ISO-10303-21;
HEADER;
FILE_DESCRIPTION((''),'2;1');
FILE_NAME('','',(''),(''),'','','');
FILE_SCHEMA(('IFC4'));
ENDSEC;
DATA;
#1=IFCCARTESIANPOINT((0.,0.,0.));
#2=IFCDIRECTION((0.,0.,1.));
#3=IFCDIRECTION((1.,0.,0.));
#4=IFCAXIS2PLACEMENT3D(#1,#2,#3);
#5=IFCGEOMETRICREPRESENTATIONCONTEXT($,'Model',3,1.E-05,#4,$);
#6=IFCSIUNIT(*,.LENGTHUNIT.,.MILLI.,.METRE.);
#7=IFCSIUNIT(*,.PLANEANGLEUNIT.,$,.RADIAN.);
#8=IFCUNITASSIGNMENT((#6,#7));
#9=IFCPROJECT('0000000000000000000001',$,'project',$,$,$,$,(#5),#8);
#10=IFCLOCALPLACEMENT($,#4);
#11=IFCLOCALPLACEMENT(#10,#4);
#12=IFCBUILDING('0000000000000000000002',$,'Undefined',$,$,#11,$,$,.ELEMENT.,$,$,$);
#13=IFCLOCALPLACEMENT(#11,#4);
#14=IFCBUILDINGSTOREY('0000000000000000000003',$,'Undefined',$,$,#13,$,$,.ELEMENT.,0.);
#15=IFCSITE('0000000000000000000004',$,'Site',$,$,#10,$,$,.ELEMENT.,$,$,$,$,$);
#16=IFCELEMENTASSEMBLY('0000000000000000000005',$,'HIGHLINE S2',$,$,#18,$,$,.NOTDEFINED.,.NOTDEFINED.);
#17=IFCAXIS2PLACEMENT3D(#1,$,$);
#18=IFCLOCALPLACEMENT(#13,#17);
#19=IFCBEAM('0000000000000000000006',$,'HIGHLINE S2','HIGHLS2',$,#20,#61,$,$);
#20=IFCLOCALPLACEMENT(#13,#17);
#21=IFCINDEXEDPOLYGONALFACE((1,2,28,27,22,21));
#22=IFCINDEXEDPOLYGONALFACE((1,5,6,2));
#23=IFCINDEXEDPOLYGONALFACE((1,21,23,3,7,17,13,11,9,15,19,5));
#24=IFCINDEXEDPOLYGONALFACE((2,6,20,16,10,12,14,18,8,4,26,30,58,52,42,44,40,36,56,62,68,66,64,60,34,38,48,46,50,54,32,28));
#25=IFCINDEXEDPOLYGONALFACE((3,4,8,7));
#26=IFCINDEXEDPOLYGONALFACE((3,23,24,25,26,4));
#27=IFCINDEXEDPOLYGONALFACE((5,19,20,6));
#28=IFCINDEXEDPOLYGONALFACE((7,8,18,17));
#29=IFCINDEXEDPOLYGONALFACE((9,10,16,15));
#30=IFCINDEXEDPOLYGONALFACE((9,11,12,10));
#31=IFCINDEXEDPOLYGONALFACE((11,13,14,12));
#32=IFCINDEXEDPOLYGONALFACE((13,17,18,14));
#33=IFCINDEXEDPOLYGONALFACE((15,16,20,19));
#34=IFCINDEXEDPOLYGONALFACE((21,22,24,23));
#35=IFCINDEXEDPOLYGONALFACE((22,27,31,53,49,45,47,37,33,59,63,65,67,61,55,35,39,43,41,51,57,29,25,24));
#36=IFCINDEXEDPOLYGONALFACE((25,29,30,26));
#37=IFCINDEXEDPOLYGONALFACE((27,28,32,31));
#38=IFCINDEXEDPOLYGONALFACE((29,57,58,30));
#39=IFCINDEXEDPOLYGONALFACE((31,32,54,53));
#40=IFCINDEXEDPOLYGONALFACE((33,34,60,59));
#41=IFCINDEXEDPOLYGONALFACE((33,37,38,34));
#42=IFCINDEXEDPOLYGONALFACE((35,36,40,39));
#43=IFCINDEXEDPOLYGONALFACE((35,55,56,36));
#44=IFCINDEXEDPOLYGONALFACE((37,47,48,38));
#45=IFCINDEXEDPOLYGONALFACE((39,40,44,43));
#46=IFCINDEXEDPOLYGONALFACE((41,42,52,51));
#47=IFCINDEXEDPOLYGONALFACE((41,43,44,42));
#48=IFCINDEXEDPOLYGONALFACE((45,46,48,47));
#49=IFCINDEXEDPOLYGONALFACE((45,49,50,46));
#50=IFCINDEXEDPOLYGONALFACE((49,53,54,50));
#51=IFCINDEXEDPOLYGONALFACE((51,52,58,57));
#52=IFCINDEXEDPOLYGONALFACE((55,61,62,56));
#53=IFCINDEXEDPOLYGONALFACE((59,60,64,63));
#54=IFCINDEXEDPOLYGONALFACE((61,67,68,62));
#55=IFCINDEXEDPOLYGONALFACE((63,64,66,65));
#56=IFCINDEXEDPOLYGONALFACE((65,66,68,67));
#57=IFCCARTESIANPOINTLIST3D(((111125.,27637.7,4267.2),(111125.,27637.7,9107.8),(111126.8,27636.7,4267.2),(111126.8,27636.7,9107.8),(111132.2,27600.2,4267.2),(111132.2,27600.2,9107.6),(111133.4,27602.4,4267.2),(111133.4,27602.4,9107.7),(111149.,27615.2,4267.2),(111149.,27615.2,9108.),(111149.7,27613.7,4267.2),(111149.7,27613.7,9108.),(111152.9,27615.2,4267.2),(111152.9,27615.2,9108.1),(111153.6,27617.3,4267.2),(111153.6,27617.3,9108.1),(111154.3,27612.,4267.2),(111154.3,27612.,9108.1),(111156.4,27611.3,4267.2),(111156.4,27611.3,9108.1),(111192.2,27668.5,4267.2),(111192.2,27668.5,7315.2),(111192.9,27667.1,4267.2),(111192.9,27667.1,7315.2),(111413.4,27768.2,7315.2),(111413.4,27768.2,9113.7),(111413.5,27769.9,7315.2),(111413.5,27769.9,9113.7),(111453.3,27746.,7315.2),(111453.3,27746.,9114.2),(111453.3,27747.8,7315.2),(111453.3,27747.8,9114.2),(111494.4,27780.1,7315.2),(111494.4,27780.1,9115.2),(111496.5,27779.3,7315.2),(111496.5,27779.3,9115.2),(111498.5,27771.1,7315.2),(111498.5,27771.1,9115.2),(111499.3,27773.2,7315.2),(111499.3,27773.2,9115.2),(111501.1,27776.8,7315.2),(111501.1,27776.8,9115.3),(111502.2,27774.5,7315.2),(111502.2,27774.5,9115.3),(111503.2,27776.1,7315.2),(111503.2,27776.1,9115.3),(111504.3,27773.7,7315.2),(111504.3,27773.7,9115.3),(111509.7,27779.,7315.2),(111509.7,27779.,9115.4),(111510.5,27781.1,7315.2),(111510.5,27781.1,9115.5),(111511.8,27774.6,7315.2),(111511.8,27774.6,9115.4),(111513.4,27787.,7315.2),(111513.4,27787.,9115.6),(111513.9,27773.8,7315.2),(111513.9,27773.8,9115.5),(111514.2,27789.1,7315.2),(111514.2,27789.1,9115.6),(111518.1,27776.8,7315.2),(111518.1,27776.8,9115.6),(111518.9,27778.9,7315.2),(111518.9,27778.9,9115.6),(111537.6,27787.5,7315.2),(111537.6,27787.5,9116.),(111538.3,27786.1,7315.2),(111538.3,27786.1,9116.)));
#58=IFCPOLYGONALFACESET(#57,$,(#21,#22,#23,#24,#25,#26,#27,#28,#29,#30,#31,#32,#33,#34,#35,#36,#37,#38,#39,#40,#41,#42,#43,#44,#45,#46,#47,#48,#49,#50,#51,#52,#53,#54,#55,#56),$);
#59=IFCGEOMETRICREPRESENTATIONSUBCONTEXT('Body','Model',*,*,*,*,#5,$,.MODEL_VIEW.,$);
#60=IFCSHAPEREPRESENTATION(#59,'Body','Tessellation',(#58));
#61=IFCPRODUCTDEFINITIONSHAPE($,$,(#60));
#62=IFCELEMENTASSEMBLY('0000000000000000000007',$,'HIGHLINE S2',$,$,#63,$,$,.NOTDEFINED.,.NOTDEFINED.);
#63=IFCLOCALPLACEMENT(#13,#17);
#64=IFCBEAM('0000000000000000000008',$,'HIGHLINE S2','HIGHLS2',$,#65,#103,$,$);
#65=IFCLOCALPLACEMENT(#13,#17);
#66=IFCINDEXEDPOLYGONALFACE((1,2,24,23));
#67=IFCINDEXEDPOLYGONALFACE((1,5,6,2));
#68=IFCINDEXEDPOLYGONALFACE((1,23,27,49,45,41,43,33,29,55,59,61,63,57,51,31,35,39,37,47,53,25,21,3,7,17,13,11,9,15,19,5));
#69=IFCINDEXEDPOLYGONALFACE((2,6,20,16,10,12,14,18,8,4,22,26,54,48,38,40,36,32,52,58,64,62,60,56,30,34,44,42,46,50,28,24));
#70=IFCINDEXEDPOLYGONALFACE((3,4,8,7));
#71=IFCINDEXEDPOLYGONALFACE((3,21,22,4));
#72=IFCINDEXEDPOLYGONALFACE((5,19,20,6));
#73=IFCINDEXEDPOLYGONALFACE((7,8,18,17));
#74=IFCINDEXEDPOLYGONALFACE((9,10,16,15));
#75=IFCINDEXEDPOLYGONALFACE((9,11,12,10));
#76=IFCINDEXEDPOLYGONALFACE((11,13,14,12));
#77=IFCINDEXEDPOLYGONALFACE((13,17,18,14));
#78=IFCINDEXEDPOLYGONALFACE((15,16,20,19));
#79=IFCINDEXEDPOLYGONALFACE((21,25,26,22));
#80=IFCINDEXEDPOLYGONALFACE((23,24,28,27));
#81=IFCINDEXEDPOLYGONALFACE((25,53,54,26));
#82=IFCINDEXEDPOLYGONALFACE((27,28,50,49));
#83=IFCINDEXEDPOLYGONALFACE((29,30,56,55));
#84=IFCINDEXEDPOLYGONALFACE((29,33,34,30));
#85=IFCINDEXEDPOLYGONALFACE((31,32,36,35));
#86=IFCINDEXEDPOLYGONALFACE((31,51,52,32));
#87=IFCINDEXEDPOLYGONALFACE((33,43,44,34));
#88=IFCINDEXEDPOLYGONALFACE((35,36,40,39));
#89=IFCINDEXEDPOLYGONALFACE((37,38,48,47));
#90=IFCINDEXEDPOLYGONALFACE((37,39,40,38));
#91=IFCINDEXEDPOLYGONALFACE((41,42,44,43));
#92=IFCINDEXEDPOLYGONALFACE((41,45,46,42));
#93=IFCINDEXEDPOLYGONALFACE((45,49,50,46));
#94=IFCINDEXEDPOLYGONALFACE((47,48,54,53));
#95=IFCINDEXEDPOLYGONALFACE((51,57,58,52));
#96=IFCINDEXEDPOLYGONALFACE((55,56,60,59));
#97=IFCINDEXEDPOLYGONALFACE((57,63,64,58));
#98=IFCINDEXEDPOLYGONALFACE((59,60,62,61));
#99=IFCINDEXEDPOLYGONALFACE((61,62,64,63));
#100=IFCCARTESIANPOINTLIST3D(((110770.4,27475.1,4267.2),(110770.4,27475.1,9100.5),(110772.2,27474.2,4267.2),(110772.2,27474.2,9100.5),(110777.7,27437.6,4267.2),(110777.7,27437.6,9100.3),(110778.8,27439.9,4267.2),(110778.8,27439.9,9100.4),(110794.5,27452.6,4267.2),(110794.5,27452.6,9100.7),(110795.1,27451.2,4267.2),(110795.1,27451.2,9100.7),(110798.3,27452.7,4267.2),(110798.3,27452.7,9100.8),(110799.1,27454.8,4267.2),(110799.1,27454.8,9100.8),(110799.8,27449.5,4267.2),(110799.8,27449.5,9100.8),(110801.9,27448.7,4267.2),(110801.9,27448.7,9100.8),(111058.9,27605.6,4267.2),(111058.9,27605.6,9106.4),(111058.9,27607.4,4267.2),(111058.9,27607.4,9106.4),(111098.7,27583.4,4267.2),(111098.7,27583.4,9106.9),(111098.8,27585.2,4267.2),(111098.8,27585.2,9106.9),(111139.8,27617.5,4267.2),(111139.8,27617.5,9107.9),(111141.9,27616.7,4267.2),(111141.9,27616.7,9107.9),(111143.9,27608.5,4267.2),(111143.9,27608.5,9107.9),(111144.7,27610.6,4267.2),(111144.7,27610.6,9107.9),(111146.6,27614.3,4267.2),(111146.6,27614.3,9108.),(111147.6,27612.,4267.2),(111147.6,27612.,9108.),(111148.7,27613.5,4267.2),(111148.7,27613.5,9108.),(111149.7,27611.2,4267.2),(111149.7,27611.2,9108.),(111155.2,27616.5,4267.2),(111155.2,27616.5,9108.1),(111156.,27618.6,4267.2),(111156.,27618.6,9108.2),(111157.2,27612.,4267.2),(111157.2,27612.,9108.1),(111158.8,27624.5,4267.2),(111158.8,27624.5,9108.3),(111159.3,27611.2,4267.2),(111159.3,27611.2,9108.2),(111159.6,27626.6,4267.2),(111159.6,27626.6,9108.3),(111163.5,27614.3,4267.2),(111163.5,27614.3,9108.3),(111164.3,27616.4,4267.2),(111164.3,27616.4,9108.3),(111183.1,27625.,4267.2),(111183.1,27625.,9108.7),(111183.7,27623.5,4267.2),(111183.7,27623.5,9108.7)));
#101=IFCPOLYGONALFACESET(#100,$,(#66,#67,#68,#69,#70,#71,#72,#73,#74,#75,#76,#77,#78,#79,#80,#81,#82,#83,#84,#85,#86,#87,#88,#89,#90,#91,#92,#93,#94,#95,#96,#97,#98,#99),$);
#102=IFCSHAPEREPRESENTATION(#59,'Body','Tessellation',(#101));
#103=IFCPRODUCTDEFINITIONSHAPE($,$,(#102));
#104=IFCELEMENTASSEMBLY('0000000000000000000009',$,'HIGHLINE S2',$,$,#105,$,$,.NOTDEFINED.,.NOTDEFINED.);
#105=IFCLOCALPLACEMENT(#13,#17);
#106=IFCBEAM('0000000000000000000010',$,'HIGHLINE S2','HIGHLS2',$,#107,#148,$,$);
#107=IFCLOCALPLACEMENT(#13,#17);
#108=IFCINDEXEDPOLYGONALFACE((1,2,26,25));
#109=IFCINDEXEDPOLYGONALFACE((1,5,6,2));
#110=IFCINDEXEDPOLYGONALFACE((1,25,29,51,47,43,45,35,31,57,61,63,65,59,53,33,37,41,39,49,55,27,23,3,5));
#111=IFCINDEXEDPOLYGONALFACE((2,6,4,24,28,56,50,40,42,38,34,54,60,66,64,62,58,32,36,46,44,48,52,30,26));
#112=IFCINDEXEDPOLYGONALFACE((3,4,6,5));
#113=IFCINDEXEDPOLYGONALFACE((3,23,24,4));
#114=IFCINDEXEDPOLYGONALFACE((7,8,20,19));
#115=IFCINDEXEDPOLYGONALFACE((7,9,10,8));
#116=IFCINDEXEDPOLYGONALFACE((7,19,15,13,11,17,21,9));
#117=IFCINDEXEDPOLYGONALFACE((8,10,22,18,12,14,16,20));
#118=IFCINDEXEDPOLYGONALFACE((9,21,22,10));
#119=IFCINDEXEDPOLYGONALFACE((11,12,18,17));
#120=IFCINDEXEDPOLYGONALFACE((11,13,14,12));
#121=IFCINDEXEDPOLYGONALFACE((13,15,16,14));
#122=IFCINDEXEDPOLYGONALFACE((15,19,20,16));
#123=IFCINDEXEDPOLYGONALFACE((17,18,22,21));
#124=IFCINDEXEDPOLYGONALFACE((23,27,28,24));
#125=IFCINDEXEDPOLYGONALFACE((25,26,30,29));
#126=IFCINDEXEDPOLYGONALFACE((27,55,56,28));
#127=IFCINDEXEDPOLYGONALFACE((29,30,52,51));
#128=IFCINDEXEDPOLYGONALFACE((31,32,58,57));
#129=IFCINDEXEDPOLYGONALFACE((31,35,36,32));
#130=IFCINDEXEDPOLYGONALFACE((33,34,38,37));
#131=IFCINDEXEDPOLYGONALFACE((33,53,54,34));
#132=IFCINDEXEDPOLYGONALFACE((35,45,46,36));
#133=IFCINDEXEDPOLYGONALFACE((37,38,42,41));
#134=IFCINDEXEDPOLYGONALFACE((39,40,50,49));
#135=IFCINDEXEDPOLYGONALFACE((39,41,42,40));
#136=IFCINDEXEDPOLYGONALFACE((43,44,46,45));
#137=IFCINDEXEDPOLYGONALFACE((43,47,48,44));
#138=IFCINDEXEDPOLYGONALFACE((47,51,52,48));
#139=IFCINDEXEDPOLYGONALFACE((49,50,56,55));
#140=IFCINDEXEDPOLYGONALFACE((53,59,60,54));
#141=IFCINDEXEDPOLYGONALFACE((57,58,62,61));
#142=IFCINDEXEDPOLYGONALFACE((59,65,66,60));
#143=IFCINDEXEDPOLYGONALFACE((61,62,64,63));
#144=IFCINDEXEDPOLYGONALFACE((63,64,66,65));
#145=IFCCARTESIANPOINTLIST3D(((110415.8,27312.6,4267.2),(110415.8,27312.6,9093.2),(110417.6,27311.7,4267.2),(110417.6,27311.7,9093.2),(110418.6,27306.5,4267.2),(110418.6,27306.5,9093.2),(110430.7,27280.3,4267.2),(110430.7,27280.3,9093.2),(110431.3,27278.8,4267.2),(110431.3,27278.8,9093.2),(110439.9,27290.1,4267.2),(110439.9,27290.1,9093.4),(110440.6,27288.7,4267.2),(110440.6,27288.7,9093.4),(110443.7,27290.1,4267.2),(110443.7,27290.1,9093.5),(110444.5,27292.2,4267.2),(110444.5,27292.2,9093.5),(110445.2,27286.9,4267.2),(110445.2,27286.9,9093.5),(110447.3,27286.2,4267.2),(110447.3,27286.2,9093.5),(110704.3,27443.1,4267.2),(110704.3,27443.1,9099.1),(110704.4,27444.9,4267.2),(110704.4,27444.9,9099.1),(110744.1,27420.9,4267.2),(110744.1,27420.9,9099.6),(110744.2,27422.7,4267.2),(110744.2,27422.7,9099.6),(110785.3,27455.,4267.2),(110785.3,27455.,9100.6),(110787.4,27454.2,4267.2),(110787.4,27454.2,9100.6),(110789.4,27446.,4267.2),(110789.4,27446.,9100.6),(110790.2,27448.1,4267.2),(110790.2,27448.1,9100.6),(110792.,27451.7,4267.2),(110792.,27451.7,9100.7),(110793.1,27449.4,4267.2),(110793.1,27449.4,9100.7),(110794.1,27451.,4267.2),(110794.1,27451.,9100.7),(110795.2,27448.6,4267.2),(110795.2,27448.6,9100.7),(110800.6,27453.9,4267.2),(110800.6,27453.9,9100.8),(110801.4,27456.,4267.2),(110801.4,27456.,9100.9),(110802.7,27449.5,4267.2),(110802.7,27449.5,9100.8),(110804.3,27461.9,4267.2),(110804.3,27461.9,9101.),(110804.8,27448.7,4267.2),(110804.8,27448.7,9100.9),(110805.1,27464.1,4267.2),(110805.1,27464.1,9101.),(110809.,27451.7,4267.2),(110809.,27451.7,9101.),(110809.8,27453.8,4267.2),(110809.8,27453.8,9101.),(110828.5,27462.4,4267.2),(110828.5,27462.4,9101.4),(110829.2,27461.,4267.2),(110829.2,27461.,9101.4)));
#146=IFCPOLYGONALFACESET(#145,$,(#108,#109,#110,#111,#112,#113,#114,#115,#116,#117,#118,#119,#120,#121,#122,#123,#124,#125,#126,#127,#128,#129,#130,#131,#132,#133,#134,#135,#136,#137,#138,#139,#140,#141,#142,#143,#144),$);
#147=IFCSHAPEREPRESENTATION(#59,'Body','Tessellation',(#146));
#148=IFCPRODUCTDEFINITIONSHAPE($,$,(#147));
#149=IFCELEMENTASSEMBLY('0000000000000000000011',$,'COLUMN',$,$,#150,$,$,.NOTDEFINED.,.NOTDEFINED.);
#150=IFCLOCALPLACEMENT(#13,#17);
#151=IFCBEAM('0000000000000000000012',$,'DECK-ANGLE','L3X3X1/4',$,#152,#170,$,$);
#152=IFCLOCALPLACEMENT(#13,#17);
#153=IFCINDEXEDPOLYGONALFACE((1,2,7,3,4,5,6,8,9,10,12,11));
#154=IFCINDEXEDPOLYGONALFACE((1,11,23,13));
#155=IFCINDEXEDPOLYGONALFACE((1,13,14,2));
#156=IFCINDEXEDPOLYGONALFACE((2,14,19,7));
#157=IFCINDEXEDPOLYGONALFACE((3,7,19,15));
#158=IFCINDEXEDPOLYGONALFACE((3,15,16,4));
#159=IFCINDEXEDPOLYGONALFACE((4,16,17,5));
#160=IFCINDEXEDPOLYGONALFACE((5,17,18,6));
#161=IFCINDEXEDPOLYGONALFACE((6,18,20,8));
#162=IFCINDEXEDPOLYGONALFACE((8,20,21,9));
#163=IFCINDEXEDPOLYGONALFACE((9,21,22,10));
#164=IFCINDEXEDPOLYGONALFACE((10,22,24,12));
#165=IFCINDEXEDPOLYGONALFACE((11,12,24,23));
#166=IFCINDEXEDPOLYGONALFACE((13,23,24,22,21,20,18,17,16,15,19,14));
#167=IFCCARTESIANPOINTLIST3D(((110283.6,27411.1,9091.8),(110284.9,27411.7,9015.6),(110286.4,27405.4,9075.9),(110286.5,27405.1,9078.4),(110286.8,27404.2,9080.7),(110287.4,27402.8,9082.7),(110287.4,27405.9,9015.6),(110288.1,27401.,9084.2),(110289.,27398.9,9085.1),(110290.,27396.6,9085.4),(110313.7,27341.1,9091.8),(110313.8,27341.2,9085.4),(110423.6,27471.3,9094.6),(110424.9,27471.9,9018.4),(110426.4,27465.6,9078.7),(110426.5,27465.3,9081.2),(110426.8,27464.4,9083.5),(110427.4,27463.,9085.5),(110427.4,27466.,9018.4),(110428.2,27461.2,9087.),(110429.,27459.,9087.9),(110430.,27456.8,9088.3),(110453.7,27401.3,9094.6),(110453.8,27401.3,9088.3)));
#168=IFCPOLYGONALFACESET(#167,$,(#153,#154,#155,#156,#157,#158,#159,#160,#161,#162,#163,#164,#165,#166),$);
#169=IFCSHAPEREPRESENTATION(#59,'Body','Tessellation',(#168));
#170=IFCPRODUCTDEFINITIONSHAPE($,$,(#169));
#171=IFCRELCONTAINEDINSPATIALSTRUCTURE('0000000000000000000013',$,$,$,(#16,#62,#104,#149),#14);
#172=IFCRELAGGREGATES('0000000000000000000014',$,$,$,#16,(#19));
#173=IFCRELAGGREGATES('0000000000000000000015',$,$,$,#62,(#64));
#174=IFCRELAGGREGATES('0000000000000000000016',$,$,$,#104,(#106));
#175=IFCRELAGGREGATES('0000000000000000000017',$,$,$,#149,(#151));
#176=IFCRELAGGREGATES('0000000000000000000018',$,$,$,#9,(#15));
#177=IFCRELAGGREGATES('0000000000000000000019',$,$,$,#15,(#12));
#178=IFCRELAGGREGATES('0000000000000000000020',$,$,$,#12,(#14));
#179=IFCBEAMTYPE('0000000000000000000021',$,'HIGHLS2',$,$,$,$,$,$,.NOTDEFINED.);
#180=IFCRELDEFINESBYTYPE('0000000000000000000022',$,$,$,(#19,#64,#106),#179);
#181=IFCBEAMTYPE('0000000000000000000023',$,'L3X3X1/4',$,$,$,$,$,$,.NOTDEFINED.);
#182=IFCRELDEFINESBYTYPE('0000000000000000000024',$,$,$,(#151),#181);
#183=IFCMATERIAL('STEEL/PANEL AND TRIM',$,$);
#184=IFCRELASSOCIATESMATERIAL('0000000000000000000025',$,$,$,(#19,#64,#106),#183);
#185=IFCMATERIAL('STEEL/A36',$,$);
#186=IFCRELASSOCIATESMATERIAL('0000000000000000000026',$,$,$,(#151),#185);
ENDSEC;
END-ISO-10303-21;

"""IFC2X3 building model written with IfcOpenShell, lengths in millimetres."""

from ifc_helpers import new_model, si_unit, frame, origin_with_axes, origin_2d_with_axis, place, context, subcontext, project, spatial, polyline, l_section, outline, extrude, boolean, clip, halfspace, material, type_object, element, aggregate, save


model = new_model("IFC2X3")

# Units and contexts
model_context = context("Model", 3, precision=1e-05, world=origin_with_axes())
body_context = subcontext(model_context, "Body", "Model", "MODEL_VIEW")
ifc_project = project(units=[si_unit("LENGTHUNIT", "METRE", prefix="MILLI"), si_unit("PLANEANGLEUNIT", "RADIAN")], contexts=[model_context])

# Site, building, storey
site_placement = place(None, origin_with_axes())
site = spatial("IfcSite", under=ifc_project, at=site_placement, Name="Site", CompositionType="ELEMENT")
building_placement = place(site_placement, origin_with_axes())
building = spatial("IfcBuilding", under=site, at=building_placement, Name="Undefined", CompositionType="ELEMENT")
storey_placement = place(building_placement, origin_with_axes())
storey = spatial("IfcBuildingStorey", under=building, at=storey_placement, Name="Undefined", CompositionType="ELEMENT", Elevation=0.0)

# Element assemblies, beams
ifc_material_1 = material(Name="STEEL/PANEL AND TRIM")
beam_type_1 = type_object("IfcBeamType", Name="HIGHLS2", PredefinedType="NOTDEFINED")
assembly_1_placement = place(storey_placement, origin_with_axes())
assembly_1 = element("IfcElementAssembly", 1, at=assembly_1_placement, inside=storey, Name="HIGHLINE S2", AssemblyPlace="NOTDEFINED", PredefinedType="NOTDEFINED")
beam_1_placement = place(assembly_1_placement, frame((111125.0, 27637.7, 4267.2), z_axis=(0.41674, -0.909026, 0.0), x_axis=(0.0, 0.0, 1.0)))
beam_1 = element("IfcBeam", 2, at=beam_1_placement, type_object=beam_type_1, material=ifc_material_1, Name="HIGHLINE S2", Description="HIGHLS2", context=body_context, shape_type="CSG", body=[
    boolean("DIFFERENCE", boolean("DIFFERENCE", extrude(outline(polyline([(415.4, 26.1), (415.4, 37.3), (437.6, 37.3), (437.6, 35.7), (417.0, 35.7), (417.0, 24.5), (395.1, 24.5), (395.1, 34.4), (401.5, 34.4), (401.5, 31.9), (408.7, 31.9), (408.7, 36.8), (344.4, 36.8), (317.4, 0.0), (0.0, 0.0), (-9.0, 37.1), (17.6, 37.1), (17.6, 30.5), (12.5, 30.5), (12.5, 32.1), (16.0, 32.1), (16.0, 35.5), (-7.0, 35.5), (1.2, 1.6), (316.6, 1.6), (343.6, 38.4), (410.3, 38.4), (410.3, 30.3), (400.0, 30.3), (400.0, 32.8), (396.7, 32.8), (396.7, 26.1), (415.4, 26.1)])), frame((10000.0, 0.0, 0.0), z_axis=(-1.0, 0.0, 0.0), x_axis=(0.0, -1.0, 0.0)), (0.0, 0.0, 1.0), 10000.0), extrude(outline(polyline([(0.0, 0.0), (6400.8, 0.0), (6400.8, 3048.0), (0.0, 3048.0), (0.0, 0.0)])), frame((0.0, -74.0, -9.8), z_axis=(0.0, 0.0, 1.0), x_axis=(0.0, -1.0, 0.0)), (0.0, 0.0, 1.0), 58.0)), halfspace(frame((4831.2, 500.0, 500.0), z_axis=(0.999825, 0.018709, 0.0), x_axis=(0.0, 0.0, -1.0)), False)),
])
aggregate(assembly_1, [beam_1])
assembly_2_placement = place(storey_placement, origin_with_axes())
assembly_2 = element("IfcElementAssembly", 3, at=assembly_2_placement, inside=storey, Name="HIGHLINE S2", AssemblyPlace="NOTDEFINED", PredefinedType="NOTDEFINED")
beam_2_placement = place(assembly_2_placement, frame((110770.4, 27475.1, 4267.2), z_axis=(0.41674, -0.909026, 0.0), x_axis=(0.0, 0.0, 1.0)))
beam_2 = element("IfcBeam", 4, at=beam_2_placement, type_object=beam_type_1, material=ifc_material_1, Name="HIGHLINE S2", Description="HIGHLS2", context=body_context, shape_type="CSG", body=[
    boolean("DIFFERENCE", boolean("DIFFERENCE", extrude(outline(polyline([(415.4, 26.1), (415.4, 37.3), (437.6, 37.3), (437.6, 35.7), (417.0, 35.7), (417.0, 24.5), (395.1, 24.5), (395.1, 34.4), (401.5, 34.4), (401.5, 31.9), (408.7, 31.9), (408.7, 36.8), (344.4, 36.8), (317.4, 0.0), (0.0, 0.0), (-9.0, 37.1), (17.6, 37.1), (17.6, 30.5), (12.5, 30.5), (12.5, 32.1), (16.0, 32.1), (16.0, 35.5), (-7.0, 35.5), (1.2, 1.6), (316.6, 1.6), (343.6, 38.4), (410.3, 38.4), (410.3, 30.3), (400.0, 30.3), (400.0, 32.8), (396.7, 32.8), (396.7, 26.1), (415.4, 26.1)])), frame((10000.0, 0.0, 0.0), z_axis=(-1.0, 0.0, 0.0), x_axis=(0.0, -1.0, 0.0)), (0.0, 0.0, 1.0), 10000.0), extrude(outline(polyline([(0.0, 0.0), (6400.8, 0.0), (6400.8, 3048.0), (0.0, 3048.0), (0.0, 0.0)])), frame((0.0, -464.0, -9.8), z_axis=(0.0, 0.0, 1.0), x_axis=(0.0, -1.0, 0.0)), (0.0, 0.0, 1.0), 58.0)), halfspace(frame((4823.9, 500.0, 500.0), z_axis=(0.999825, 0.018709, 0.0), x_axis=(0.0, 0.0, -1.0)), False)),
])
aggregate(assembly_2, [beam_2])
assembly_3_placement = place(storey_placement, origin_with_axes())
assembly_3 = element("IfcElementAssembly", 5, at=assembly_3_placement, inside=storey, Name="HIGHLINE S2", AssemblyPlace="NOTDEFINED", PredefinedType="NOTDEFINED")
beam_3_placement = place(assembly_3_placement, frame((110415.8, 27312.6, 4267.2), z_axis=(0.41674, -0.909026, 0.0), x_axis=(0.0, 0.0, 1.0)))
beam_3 = element("IfcBeam", 6, at=beam_3_placement, type_object=beam_type_1, material=ifc_material_1, Name="HIGHLINE S2", Description="HIGHLS2", context=body_context, shape_type="Clipping", body=[
    clip(clip(extrude(outline(polyline([(415.4, 26.1), (415.4, 37.3), (437.6, 37.3), (437.6, 35.7), (417.0, 35.7), (417.0, 24.5), (395.1, 24.5), (395.1, 34.4), (401.5, 34.4), (401.5, 31.9), (408.7, 31.9), (408.7, 36.8), (344.4, 36.8), (317.4, 0.0), (0.0, 0.0), (-9.0, 37.1), (17.6, 37.1), (17.6, 30.5), (12.5, 30.5), (12.5, 32.1), (16.0, 32.1), (16.0, 35.5), (-7.0, 35.5), (1.2, 1.6), (316.6, 1.6), (343.6, 38.4), (410.3, 38.4), (410.3, 30.3), (400.0, 30.3), (400.0, 32.8), (396.7, 32.8), (396.7, 26.1), (415.4, 26.1)])), frame((10000.0, 0.0, 0.0), z_axis=(-1.0, 0.0, 0.0), x_axis=(0.0, -1.0, 0.0)), (0.0, 0.0, 1.0), 10000.0), halfspace(frame((4816.6, 500.0, 500.0), z_axis=(0.999825, 0.018709, 0.0), x_axis=(0.0, 0.0, -1.0)), False)), halfspace(frame((10000.0, 0.0, -500.0), z_axis=(0.0, 1.0, 0.0), x_axis=(0.0, 0.0, 1.0)), False)),
])
aggregate(assembly_3, [beam_3])

# Element assembly, beam
assembly_4_placement = place(storey_placement, origin_with_axes())
assembly_4 = element("IfcElementAssembly", 7, at=assembly_4_placement, inside=storey, Name="COLUMN", AssemblyPlace="NOTDEFINED", PredefinedType="NOTDEFINED")
ifc_material_2 = material(Name="STEEL/A36")
beam_type_2 = type_object("IfcBeamType", Name="L3X3X1/4", PredefinedType="NOTDEFINED")
beam_4_placement = place(assembly_4_placement, frame((110439.3, 27436.6, 9056.5), z_axis=(0.016971, 0.007293, -0.999829), x_axis=(-0.918596, -0.394765, -0.018472)))
beam_4 = element("IfcBeam", 8, at=beam_4_placement, type_object=beam_type_2, material=ifc_material_2, Name="DECK-ANGLE", Description="L3X3X1/4", context=body_context, shape_type="SweptSolid", body=[
    extrude(l_section(Depth=76.2, Width=76.2, Thickness=6.3, FilletRadius=9.5, at=origin_2d_with_axis()), frame((152.4, 0.0, 0.0), z_axis=(-1.0, 0.0, 0.0), x_axis=(0.0, -1.0, 0.0)), (0.0, 0.0, 1.0), 152.4),
])

aggregate(assembly_4, [beam_4])

save(model, "model.ifc")
